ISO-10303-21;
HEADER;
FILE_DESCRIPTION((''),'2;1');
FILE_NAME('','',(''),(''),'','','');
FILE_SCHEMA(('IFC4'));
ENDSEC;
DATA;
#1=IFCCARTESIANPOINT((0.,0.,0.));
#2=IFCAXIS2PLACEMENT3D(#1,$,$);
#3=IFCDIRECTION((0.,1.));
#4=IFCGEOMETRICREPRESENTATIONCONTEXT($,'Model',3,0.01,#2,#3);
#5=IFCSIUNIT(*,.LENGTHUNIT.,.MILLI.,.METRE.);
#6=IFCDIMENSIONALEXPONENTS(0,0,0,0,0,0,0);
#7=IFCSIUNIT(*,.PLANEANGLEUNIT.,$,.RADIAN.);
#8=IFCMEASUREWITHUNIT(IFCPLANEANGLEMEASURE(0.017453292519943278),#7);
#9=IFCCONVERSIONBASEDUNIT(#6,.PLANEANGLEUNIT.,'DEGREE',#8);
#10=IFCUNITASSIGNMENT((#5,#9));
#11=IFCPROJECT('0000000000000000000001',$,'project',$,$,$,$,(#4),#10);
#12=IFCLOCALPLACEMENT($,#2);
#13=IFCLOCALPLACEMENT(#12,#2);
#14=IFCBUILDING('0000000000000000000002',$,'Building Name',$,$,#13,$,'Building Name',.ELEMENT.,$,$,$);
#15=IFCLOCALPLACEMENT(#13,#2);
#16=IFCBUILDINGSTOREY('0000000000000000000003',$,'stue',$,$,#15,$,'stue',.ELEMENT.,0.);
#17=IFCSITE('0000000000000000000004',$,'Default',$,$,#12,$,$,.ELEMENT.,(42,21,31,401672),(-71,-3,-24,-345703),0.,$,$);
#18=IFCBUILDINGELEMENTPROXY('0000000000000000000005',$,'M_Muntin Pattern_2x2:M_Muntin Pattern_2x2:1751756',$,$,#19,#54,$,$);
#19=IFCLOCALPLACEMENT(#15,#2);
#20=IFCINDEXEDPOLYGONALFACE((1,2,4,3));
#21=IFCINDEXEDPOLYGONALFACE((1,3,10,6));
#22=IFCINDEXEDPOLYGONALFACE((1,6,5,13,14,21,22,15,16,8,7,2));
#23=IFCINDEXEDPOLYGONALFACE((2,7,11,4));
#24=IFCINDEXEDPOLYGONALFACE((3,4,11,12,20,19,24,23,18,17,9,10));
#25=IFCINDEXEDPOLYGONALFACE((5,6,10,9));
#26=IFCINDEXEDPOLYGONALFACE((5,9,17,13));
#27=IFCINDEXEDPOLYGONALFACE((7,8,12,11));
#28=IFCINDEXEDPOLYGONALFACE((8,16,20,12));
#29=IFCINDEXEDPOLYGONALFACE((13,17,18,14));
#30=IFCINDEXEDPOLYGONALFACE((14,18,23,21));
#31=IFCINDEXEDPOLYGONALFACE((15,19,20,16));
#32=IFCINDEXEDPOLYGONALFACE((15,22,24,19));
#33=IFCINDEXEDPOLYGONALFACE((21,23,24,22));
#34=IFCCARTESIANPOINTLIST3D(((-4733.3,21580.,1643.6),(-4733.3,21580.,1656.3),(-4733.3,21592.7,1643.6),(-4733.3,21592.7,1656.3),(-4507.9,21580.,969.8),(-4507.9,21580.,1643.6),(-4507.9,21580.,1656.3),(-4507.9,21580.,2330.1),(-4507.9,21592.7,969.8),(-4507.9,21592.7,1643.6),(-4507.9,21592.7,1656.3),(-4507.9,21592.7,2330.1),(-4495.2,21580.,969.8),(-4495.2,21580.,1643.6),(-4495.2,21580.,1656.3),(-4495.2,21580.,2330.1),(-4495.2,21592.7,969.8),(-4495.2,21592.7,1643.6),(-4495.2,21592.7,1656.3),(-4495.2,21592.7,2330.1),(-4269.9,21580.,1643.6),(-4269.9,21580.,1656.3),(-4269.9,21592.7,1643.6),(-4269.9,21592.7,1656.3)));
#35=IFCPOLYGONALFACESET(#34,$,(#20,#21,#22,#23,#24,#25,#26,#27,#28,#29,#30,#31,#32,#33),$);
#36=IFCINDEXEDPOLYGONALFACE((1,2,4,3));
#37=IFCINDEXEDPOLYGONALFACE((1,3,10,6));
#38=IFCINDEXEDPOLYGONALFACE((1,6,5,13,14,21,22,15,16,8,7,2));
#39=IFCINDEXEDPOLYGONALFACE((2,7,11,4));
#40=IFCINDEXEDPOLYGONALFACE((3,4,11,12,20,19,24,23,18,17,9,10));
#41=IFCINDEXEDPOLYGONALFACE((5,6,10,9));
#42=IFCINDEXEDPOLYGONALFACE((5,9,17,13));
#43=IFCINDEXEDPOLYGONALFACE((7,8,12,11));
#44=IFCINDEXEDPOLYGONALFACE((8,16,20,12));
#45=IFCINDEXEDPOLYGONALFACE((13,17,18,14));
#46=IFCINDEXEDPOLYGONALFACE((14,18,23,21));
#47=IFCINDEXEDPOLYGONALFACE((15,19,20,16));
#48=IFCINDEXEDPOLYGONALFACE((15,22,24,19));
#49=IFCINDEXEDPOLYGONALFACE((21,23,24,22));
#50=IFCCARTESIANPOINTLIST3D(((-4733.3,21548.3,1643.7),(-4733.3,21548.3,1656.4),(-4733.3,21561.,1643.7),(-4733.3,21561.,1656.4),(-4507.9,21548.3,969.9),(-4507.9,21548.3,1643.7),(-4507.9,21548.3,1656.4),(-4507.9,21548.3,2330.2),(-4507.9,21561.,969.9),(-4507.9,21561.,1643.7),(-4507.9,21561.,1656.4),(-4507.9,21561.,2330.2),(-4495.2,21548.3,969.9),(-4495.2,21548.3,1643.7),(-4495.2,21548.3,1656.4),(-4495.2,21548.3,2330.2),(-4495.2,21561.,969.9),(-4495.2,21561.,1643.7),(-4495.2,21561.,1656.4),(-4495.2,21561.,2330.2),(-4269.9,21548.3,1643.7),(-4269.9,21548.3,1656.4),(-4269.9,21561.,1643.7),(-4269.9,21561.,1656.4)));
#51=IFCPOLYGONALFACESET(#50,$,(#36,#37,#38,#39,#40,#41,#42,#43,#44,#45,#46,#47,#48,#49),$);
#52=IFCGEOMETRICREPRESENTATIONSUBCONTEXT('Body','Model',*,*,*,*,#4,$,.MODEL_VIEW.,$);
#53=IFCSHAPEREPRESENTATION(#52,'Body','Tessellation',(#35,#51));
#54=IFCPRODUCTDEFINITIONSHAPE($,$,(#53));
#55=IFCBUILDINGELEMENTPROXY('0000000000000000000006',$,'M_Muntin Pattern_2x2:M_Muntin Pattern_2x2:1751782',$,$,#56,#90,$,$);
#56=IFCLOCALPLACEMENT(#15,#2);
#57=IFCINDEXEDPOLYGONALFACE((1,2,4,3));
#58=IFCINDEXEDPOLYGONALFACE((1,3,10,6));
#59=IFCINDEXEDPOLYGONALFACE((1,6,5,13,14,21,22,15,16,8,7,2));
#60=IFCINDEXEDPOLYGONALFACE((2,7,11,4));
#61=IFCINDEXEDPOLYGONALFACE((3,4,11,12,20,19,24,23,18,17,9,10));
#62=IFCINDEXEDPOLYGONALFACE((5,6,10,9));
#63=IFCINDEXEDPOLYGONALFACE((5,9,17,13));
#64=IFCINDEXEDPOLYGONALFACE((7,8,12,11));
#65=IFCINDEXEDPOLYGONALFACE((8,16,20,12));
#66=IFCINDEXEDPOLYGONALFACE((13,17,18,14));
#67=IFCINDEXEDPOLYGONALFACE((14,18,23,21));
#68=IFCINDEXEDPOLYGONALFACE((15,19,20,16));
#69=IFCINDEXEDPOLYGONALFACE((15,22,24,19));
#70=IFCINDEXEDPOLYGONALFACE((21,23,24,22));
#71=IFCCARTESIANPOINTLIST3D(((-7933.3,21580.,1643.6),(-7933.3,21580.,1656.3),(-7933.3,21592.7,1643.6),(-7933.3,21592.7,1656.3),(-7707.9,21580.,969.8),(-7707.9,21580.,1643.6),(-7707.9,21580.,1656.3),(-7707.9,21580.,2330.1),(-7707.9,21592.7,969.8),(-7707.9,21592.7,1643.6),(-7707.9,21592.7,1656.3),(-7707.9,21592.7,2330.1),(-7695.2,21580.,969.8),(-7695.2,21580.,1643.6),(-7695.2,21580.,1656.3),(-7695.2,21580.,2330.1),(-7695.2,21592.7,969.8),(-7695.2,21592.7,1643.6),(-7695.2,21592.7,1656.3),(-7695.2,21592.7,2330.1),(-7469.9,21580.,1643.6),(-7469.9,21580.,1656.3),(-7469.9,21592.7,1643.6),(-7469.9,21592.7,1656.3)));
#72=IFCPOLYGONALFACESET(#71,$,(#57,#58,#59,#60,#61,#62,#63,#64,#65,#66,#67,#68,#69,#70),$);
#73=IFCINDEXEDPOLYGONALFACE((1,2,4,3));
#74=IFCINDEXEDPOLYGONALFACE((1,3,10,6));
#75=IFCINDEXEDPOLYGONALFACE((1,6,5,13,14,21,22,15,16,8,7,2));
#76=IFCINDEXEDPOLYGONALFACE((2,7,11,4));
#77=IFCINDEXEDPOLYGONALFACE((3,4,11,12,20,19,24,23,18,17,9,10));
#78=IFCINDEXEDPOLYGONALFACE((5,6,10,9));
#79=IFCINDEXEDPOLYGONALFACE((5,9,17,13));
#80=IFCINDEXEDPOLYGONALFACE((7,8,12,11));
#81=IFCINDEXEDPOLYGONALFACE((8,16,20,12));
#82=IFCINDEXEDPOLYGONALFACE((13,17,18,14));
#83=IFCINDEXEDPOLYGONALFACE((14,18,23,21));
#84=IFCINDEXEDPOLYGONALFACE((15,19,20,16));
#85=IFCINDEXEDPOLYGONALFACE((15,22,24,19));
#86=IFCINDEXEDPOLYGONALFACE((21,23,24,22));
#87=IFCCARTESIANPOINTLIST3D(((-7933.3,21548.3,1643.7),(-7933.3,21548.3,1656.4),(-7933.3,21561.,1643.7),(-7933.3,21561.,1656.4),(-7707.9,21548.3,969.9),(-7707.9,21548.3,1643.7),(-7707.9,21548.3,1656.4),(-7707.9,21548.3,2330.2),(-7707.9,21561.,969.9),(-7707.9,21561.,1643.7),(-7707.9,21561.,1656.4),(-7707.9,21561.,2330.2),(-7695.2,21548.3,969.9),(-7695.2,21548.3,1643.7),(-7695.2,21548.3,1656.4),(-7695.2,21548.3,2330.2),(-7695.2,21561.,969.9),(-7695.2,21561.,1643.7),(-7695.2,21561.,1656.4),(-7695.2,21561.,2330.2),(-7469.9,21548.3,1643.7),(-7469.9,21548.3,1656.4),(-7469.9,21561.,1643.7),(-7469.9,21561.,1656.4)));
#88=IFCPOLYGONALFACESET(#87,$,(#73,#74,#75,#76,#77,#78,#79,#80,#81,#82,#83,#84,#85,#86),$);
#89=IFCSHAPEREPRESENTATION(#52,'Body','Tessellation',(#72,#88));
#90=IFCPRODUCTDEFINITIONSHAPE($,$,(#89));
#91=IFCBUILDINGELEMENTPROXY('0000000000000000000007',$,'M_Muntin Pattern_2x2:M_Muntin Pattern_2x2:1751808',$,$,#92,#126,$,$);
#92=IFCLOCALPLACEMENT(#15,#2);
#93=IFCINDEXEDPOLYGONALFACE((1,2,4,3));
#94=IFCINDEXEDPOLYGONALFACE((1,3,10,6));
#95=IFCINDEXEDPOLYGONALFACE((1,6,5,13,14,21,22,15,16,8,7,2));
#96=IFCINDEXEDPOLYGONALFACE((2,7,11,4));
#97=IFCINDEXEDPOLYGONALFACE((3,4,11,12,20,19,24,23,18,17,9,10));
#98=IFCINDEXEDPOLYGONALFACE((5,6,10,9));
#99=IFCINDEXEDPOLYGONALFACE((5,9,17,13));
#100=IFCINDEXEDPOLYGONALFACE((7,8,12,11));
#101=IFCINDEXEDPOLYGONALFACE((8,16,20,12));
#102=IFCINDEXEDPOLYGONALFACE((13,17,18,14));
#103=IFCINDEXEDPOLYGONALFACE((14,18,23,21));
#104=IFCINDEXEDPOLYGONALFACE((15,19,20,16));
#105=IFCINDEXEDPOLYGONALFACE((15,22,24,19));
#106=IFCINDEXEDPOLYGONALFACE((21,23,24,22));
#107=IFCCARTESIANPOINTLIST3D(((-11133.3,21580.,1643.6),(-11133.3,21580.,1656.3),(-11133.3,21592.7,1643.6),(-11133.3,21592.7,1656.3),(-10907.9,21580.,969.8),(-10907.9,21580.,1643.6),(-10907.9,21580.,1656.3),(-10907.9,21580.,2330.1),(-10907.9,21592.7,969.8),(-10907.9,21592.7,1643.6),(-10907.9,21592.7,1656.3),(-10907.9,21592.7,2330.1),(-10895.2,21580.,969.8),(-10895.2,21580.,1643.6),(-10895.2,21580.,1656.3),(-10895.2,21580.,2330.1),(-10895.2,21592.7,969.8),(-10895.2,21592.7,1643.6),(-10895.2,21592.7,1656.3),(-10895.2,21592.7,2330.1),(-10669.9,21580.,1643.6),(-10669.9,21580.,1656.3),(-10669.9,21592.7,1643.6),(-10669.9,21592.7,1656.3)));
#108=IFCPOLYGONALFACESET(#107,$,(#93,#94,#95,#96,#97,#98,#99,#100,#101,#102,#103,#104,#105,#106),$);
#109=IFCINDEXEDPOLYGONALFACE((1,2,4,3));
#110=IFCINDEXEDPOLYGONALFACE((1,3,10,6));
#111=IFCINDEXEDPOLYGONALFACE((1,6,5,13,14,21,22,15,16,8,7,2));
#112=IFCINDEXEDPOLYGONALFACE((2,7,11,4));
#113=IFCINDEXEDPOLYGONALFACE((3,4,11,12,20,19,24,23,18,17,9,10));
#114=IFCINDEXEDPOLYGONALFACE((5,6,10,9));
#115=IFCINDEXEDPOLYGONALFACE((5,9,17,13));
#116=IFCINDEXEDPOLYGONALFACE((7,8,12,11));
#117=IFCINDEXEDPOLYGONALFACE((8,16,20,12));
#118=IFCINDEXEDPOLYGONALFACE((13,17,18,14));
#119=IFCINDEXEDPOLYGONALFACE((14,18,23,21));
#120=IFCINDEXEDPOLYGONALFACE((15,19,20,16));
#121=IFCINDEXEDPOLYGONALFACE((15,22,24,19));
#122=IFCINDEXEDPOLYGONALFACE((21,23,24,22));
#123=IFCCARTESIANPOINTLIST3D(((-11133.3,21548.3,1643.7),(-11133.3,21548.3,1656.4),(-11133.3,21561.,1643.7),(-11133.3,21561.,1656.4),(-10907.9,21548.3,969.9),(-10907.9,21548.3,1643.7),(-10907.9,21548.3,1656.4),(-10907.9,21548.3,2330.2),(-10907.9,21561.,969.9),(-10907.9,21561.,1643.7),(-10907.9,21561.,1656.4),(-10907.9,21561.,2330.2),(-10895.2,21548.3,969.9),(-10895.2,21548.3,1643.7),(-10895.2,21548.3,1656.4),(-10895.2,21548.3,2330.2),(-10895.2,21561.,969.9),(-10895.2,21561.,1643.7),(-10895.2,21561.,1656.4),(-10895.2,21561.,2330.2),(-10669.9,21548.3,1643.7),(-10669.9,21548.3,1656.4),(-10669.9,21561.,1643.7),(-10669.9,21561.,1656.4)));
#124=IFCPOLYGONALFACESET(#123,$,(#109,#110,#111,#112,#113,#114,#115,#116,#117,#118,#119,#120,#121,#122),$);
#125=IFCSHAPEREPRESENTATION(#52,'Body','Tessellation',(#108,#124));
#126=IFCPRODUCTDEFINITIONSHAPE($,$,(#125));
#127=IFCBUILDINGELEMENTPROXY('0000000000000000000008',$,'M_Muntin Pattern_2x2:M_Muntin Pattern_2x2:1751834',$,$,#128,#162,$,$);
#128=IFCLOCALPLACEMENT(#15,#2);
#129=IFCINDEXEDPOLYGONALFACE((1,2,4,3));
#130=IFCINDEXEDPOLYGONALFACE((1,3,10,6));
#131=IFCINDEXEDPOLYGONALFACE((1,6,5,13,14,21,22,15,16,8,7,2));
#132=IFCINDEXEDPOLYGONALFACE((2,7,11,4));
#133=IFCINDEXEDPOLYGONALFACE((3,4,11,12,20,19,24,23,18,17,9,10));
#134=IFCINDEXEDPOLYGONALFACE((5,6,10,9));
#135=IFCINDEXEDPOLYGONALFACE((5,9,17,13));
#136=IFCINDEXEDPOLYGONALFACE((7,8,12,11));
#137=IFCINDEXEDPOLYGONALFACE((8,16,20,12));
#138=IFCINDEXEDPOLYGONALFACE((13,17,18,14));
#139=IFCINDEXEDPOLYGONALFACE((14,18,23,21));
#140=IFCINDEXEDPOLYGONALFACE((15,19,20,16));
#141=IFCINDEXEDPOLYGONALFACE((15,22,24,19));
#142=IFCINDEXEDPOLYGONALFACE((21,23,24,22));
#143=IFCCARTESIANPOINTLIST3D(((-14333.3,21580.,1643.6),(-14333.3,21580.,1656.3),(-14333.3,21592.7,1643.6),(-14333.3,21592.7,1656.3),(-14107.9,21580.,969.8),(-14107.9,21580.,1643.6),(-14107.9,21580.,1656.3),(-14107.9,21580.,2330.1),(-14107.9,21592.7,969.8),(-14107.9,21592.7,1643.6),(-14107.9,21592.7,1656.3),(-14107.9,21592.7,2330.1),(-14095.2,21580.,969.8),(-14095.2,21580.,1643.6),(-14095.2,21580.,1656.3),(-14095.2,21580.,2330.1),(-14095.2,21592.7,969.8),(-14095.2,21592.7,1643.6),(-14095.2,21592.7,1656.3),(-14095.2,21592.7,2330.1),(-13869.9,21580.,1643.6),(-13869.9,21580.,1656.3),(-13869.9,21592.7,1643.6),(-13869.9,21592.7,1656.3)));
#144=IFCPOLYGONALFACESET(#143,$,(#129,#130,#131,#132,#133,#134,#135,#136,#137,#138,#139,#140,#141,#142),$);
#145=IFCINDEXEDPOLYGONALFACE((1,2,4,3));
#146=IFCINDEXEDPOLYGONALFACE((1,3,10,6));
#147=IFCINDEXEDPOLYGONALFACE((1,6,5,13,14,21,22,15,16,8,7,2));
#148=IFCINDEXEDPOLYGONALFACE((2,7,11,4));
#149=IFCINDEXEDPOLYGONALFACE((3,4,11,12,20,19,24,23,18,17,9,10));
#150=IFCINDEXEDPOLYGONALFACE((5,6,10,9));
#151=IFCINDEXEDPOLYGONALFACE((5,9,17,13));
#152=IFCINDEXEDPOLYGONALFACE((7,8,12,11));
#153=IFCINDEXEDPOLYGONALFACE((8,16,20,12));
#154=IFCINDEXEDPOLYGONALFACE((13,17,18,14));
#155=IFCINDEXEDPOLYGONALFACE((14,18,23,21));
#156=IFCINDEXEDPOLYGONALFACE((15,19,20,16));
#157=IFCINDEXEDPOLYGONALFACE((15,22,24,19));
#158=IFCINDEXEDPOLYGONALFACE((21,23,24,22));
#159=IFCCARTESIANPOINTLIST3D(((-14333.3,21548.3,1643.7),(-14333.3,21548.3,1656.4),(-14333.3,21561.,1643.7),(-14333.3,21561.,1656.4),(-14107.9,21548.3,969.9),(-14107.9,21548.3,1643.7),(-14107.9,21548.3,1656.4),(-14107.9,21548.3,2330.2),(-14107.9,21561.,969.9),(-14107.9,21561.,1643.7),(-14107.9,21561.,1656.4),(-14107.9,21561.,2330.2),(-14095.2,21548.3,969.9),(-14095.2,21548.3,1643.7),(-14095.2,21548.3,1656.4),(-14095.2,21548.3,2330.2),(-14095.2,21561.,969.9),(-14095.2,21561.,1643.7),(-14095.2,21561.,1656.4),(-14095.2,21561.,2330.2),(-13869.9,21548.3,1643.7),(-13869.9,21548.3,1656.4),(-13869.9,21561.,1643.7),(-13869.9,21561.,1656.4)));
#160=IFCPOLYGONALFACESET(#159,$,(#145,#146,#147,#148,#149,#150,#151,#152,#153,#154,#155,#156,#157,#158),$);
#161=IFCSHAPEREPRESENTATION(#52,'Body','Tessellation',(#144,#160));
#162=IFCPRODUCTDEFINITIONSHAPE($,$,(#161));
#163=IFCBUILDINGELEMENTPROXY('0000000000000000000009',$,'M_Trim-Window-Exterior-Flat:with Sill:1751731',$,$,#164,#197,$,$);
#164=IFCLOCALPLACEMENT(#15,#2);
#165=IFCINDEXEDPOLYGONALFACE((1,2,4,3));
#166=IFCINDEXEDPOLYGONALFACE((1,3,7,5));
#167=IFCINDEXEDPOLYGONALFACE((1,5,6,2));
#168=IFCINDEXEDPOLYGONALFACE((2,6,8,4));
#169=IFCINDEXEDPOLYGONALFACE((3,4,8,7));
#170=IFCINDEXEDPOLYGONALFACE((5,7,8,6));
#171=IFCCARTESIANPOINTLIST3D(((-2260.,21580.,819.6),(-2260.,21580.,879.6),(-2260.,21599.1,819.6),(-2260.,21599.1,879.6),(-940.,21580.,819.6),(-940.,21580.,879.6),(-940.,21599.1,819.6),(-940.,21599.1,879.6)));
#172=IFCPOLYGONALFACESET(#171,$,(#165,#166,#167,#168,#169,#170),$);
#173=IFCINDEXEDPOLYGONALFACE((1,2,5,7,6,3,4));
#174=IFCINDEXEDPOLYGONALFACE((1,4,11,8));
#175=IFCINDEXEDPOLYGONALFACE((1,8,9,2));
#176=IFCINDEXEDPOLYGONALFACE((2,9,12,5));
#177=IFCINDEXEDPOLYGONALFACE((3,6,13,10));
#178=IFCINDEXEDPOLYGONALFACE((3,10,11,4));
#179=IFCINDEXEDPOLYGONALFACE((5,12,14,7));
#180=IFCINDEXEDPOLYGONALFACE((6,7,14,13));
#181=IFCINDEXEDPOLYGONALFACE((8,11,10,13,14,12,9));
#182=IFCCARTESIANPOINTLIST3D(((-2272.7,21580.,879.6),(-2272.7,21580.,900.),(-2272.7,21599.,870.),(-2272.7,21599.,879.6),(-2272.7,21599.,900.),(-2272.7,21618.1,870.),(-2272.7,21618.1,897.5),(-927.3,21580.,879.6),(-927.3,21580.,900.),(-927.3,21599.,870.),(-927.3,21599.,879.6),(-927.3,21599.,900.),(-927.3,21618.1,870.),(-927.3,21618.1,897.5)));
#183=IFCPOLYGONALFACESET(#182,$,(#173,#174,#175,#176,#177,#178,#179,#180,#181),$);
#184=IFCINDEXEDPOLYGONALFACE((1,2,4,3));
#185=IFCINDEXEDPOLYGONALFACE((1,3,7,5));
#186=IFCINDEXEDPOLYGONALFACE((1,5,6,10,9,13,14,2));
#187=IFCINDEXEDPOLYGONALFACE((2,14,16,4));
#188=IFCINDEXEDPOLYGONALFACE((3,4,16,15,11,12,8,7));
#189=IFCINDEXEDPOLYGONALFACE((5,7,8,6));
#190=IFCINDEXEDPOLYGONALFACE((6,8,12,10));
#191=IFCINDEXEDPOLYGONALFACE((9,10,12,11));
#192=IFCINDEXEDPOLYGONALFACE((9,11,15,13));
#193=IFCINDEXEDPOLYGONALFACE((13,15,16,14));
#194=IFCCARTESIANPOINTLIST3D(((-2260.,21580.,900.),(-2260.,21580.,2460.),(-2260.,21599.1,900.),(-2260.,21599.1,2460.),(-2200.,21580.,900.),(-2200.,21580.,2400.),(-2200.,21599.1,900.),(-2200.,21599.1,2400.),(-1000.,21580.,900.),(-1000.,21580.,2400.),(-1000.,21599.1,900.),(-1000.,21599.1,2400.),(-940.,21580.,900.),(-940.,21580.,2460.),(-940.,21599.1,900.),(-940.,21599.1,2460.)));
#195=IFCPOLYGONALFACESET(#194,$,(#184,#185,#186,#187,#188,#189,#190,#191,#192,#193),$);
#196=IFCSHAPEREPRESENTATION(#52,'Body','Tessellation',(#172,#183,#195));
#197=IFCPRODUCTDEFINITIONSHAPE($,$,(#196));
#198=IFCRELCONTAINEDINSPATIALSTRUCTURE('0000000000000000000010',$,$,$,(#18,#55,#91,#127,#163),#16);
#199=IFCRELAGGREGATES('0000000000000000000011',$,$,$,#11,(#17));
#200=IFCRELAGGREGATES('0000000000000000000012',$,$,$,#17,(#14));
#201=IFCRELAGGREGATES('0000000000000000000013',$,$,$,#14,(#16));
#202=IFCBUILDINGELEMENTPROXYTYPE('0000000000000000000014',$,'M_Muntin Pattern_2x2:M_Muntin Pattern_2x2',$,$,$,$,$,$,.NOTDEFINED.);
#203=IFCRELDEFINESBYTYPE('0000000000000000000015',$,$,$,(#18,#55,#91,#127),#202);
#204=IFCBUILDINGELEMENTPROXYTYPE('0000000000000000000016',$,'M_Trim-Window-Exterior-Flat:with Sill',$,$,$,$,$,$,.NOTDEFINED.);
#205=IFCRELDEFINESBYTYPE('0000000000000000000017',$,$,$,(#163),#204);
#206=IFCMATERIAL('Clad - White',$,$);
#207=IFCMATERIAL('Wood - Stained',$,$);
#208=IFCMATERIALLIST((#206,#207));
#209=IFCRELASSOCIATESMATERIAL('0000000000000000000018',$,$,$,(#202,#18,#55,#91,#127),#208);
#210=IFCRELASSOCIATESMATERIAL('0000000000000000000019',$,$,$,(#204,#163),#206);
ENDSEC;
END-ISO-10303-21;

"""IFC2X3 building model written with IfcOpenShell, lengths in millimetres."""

from ifc_helpers import new_model, entity, si_unit, converted_unit, direction, frame, frame_2d, origin, place, context, subcontext, project, spatial, polyline, rectangle, outline, extrude, source, transform, mapped, material, material_list, type_object, type_shapes, element, save


model = new_model("IFC2X3")

# Units and contexts
model_context = context("Model", 3, precision=0.01, world=origin(), true_north=direction((0.0, 1.0)))
body_context = subcontext(model_context, "Body", "Model", "MODEL_VIEW")
ifc_project = project(units=[si_unit("LENGTHUNIT", "METRE", prefix="MILLI"), converted_unit("PLANEANGLEUNIT", "DEGREE", entity("IfcPlaneAngleMeasure", 0.017453292519943278), si_unit("PLANEANGLEUNIT", "RADIAN"), dimensions=[0, 0, 0, 0, 0, 0, 0])], contexts=[model_context])

# Site, building, storey
site_placement = place(None, origin())
site = spatial("IfcSite", under=ifc_project, at=site_placement, Name="Default", CompositionType="ELEMENT", RefLatitude=(42, 21, 31, 401672), RefLongitude=(-71, -3, -24, -345703), RefElevation=0.0)
building_placement = place(site_placement, origin())
building = spatial("IfcBuilding", under=site, at=building_placement, Name="Building Name", LongName="Building Name", CompositionType="ELEMENT")
storey_placement = place(building_placement, origin())
storey = spatial("IfcBuildingStorey", under=building, at=storey_placement, Name="stue", LongName="stue", CompositionType="ELEMENT", Elevation=0.0)

# Building element proxies
ifc_material_1 = material(Name="Clad - White")
ifc_material_2 = material(Name="Wood - Stained")
ifc_material_list = material_list([ifc_material_1, ifc_material_2])
building_element_proxy_type_1 = type_object("IfcBuildingElementProxyType", Name="M_Muntin Pattern_2x2:M_Muntin Pattern_2x2", PredefinedType="NOTDEFINED", material=ifc_material_list)
shared_shape_1 = source(origin(), body_context, "Body", "SweptSolid", [
    extrude(outline(polyline([(6.4, -6.4), (680.1, -6.4), (680.1, 6.3), (6.4, 6.3), (6.4, 231.7), (-6.3, 231.7), (-6.3, 6.3), (-680.2, 6.3), (-680.2, -6.4), (-6.3, -6.4), (-6.3, -231.7), (6.4, -231.7), (6.4, -6.4)])), frame((0.0, -22.2, 680.1), z_axis=(0.0, 1.0, 0.0), x_axis=(0.0, 0.0, 1.0)), (0.0, 0.0, 1.0), 12.7),
    extrude(outline(polyline([(6.4, -6.4), (680.2, -6.4), (680.2, 6.3), (6.4, 6.3), (6.4, 231.7), (-6.3, 231.7), (-6.3, 6.3), (-680.2, 6.3), (-680.2, -6.4), (-6.3, -6.4), (-6.3, -231.7), (6.4, -231.7), (6.4, -6.4)])), frame((0.0, 9.5, 680.2), z_axis=(0.0, 1.0, 0.0), x_axis=(0.0, 0.0, 1.0)), (0.0, 0.0, 1.0), 12.7),
])
type_shapes(building_element_proxy_type_1, [shared_shape_1])
for number, where, z_axis, x_axis, name in (
    (1, (-4501.6, 21570.5, 969.9), (0.0, 0.0, 1.0), (-1.0, 0.0, 0.0), "M_Muntin Pattern_2x2:M_Muntin Pattern_2x2:1751756"),
    (2, (-7701.6, 21570.5, 969.9), (0.0, 0.0, 1.0), (-1.0, 0.0, 0.0), "M_Muntin Pattern_2x2:M_Muntin Pattern_2x2:1751782"),
    (3, (-10901.6, 21570.5, 969.9), (0.0, 0.0, 1.0), (-1.0, 0.0, 0.0), "M_Muntin Pattern_2x2:M_Muntin Pattern_2x2:1751808"),
    (4, (-14101.6, 21570.5, 969.9), (0.0, 0.0, 1.0), (-1.0, 0.0, 0.0), "M_Muntin Pattern_2x2:M_Muntin Pattern_2x2:1751834"),
):
    element("IfcBuildingElementProxy", number, at=place(storey_placement, frame(where, z_axis=z_axis, x_axis=x_axis)), inside=storey, type_object=building_element_proxy_type_1, material=ifc_material_list, Name=name, context=body_context, shape_type="MappedRepresentation", body=[
        mapped(shared_shape_1, transform((0.0, 0.0, 0.0), scale=1.0)),
    ])
building_element_proxy_type_2 = type_object("IfcBuildingElementProxyType", Name="M_Trim-Window-Exterior-Flat:with Sill", PredefinedType="NOTDEFINED", material=ifc_material_1)
shared_shape_2 = source(origin(), body_context, "Body", "SweptSolid", [
    extrude(rectangle(XDim=1320.0, YDim=60.0, at=frame_2d((0.0, 0.0), x_axis=(1.0, 0.0))), frame((0.0, -1550.4, 0.0), z_axis=(0.0, 0.0, 1.0), x_axis=(-1.0, 0.0, 0.0)), (0.0, 0.0, 1.0), 19.0),
    extrude(outline(polyline([(-19.0, -15.2), (0.0, -15.2), (0.0, -5.7), (19.0, -5.7), (19.0, 14.8), (0.0, 14.8), (-19.0, 12.3), (-19.0, -15.2)])), frame((-672.7, -1514.8, 19.0), z_axis=(1.0, 0.0, 0.0), x_axis=(0.0, 0.0, -1.0)), (0.0, 0.0, 1.0), 1345.4),
    extrude(outline(polyline([(-795.0, -660.0), (765.0, -660.0), (765.0, -600.0), (-735.0, -600.0), (-735.0, 600.0), (765.0, 600.0), (765.0, 660.0), (-795.0, 660.0), (-795.0, -660.0)])), frame((0.0, -735.0, 0.0), z_axis=(0.0, 0.0, 1.0), x_axis=(0.0, -1.0, 0.0)), (0.0, 0.0, 1.0), 19.0),
])
type_shapes(building_element_proxy_type_2, [shared_shape_2])
for number, where, z_axis, x_axis, name in (
    (5, (-1600.0, 21580.0, 2400.0), (0.0, 1.0, 0.0), (-1.0, 0.0, 0.0), "M_Trim-Window-Exterior-Flat:with Sill:1751731"),
):
    element("IfcBuildingElementProxy", number, at=place(storey_placement, frame(where, z_axis=z_axis, x_axis=x_axis)), inside=storey, type_object=building_element_proxy_type_2, material=ifc_material_1, Name=name, context=body_context, shape_type="MappedRepresentation", body=[
        mapped(shared_shape_2, transform((0.0, 0.0, 0.0), scale=1.0)),
    ])

save(model, "model.ifc")
